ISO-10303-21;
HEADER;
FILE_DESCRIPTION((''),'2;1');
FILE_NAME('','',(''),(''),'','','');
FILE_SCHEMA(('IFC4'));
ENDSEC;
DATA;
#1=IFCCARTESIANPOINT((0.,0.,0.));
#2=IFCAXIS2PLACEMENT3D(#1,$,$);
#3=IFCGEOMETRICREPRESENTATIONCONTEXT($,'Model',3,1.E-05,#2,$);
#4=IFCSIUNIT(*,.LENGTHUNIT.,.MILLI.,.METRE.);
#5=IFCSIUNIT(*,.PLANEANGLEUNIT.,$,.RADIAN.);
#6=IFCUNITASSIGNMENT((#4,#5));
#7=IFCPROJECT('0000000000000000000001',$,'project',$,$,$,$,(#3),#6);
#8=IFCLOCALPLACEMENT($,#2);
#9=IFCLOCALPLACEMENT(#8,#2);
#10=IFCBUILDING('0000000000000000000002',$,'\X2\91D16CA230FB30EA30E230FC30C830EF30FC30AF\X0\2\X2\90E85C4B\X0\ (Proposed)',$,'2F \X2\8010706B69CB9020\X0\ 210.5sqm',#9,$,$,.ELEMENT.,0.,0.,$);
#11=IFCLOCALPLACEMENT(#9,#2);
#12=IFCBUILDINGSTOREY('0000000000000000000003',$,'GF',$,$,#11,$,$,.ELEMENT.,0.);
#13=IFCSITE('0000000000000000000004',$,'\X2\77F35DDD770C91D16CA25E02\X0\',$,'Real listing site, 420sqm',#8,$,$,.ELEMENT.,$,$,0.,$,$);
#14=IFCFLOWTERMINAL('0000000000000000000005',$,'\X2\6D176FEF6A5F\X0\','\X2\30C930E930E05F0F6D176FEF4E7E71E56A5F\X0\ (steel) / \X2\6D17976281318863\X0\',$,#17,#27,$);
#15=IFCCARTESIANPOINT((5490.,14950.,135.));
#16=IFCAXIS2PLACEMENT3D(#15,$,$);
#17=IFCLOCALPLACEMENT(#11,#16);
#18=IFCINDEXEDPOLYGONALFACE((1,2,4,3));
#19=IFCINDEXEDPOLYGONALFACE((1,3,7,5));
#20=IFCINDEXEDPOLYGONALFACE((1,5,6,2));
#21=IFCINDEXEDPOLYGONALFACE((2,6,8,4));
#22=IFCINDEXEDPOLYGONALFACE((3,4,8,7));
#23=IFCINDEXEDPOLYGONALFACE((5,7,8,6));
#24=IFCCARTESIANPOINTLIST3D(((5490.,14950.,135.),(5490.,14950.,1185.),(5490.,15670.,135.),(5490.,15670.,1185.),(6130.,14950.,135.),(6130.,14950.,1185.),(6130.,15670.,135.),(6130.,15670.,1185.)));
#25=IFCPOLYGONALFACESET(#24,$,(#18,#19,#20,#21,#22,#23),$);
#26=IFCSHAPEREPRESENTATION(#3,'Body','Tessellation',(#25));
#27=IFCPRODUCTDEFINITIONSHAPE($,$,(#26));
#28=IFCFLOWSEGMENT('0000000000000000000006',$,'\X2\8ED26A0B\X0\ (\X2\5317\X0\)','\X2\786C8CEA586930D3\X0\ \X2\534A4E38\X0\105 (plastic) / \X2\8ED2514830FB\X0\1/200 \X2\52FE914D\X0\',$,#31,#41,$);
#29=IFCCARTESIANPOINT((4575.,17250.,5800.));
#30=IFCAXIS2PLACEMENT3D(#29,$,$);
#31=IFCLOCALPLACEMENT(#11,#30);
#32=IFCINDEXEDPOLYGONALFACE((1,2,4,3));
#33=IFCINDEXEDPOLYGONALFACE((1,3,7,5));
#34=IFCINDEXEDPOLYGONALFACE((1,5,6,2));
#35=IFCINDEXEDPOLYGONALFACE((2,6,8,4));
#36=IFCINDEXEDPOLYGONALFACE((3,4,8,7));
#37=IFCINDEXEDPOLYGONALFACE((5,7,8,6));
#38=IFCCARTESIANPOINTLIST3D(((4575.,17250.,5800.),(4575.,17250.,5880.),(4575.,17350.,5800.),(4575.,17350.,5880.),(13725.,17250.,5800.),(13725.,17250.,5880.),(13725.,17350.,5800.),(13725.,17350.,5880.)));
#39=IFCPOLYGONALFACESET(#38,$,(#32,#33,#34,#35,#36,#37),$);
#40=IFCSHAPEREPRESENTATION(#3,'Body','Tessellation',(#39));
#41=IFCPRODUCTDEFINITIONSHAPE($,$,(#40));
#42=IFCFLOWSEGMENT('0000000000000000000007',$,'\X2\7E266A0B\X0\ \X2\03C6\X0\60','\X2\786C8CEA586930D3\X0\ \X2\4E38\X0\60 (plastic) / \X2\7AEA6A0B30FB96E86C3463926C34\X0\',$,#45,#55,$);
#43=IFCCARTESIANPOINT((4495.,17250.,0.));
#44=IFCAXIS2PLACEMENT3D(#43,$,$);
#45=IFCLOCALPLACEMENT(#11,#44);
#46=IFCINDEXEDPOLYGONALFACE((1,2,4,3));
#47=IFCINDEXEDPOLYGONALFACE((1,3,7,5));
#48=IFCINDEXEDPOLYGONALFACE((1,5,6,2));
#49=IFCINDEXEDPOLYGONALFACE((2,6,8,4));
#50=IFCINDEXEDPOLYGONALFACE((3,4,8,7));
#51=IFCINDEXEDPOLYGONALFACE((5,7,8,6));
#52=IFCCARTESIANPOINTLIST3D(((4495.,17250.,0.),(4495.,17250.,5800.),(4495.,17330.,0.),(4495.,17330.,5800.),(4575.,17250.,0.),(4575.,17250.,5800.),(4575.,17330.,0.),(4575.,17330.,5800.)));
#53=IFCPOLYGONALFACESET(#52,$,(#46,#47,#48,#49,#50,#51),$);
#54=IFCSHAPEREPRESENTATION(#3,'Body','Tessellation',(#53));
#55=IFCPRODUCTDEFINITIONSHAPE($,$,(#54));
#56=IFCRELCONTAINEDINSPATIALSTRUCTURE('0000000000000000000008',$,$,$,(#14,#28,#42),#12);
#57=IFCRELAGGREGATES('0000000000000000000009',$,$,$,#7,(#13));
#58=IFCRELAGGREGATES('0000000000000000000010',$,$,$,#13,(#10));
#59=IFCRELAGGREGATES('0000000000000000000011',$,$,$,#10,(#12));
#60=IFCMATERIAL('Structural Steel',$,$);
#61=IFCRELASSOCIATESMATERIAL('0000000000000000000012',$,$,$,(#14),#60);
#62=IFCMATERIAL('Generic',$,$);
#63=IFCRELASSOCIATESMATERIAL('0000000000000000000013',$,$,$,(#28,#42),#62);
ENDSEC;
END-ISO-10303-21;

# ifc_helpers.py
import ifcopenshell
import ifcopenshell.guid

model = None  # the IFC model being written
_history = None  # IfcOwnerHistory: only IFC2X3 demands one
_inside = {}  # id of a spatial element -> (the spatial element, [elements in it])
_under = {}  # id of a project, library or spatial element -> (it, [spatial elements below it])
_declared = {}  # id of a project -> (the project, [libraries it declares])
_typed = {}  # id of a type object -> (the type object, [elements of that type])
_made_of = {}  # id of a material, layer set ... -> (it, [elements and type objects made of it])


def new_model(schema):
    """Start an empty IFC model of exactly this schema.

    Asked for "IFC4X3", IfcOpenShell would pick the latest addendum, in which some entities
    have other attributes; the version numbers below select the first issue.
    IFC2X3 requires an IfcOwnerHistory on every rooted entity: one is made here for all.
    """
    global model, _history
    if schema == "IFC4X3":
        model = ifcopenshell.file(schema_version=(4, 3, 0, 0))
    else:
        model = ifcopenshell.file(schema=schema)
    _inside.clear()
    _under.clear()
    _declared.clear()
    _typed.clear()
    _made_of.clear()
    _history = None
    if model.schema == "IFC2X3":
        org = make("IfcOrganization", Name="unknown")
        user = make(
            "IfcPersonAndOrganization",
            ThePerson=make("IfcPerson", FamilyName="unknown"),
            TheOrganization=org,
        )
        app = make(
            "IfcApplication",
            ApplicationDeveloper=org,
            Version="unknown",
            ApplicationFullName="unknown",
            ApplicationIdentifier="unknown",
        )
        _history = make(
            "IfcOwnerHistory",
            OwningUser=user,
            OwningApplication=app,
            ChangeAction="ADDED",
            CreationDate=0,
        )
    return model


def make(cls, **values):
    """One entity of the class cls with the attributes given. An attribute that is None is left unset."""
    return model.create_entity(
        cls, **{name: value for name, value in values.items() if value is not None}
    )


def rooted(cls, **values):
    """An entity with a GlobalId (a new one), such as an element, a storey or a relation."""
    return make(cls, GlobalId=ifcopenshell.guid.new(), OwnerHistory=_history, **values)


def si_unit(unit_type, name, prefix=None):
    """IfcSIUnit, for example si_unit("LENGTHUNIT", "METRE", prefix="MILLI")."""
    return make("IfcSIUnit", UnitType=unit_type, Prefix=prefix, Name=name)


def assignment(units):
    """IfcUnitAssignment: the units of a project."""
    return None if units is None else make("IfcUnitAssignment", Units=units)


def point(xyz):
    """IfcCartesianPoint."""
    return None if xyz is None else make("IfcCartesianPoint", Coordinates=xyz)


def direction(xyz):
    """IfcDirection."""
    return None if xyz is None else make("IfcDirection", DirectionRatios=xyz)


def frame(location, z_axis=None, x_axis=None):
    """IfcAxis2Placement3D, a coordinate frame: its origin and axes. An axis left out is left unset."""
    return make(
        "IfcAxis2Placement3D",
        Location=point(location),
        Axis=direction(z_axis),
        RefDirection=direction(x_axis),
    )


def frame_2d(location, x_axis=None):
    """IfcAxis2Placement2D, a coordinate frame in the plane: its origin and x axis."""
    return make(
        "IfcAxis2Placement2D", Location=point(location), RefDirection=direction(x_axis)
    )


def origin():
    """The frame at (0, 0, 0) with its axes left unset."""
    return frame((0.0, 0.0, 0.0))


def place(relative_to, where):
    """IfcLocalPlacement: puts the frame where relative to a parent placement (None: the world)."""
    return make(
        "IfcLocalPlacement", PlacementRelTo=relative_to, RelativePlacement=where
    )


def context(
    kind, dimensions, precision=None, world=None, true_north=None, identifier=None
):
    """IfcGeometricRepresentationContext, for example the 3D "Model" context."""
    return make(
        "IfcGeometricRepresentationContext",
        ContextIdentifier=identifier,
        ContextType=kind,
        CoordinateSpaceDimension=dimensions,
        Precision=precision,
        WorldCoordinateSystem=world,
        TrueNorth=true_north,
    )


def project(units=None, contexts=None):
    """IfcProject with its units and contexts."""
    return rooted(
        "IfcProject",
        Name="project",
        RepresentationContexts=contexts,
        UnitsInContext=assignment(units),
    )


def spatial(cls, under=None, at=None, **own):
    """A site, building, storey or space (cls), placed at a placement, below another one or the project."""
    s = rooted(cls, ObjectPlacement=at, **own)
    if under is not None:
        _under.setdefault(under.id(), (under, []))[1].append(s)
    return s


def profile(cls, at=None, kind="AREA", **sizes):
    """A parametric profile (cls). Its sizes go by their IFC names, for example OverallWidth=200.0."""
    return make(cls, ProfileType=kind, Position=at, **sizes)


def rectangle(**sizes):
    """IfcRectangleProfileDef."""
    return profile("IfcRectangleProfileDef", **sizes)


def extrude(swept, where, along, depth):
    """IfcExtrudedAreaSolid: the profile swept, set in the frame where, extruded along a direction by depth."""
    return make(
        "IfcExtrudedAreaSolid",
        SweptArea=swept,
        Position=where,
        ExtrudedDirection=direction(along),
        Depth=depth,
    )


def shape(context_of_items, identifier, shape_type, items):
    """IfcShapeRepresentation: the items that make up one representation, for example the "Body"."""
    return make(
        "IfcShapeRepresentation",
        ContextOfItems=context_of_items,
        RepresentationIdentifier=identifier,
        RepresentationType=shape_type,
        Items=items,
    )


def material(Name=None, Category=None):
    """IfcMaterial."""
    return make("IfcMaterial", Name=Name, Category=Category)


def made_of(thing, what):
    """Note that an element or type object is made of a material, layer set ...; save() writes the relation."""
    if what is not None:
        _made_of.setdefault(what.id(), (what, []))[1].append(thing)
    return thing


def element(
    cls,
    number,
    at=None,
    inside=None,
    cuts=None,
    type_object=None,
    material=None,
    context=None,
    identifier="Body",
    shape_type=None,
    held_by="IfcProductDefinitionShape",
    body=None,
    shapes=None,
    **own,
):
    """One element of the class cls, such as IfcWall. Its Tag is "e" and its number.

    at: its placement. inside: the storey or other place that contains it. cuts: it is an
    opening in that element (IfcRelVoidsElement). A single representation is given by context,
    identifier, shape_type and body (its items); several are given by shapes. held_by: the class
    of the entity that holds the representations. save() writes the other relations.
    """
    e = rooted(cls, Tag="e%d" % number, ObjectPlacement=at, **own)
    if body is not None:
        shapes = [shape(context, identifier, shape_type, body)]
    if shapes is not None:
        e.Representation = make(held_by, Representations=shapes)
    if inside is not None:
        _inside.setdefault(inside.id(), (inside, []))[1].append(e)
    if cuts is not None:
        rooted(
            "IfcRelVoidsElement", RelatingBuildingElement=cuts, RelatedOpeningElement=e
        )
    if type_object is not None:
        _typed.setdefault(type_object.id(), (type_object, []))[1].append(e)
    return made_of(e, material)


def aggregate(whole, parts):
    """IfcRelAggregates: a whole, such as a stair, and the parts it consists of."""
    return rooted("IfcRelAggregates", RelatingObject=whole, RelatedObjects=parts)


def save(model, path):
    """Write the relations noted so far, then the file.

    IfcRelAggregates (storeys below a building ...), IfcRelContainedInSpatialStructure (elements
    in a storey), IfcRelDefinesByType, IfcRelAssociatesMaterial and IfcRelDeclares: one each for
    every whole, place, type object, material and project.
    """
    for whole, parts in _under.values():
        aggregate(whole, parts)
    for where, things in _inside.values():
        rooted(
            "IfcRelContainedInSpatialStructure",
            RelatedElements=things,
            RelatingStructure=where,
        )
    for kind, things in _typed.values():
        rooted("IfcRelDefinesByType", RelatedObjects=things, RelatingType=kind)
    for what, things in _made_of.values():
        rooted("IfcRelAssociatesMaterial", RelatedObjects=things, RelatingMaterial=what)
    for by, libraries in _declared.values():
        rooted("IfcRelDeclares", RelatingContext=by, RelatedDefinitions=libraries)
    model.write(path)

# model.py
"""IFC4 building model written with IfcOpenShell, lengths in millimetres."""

from ifc_helpers import new_model, si_unit, frame, frame_2d, origin, place, context, project, spatial, rectangle, extrude, material, element, save


model = new_model("IFC4")

# Units and contexts
model_context = context("Model", 3, precision=1e-05, world=origin())
ifc_project = project(units=[si_unit("LENGTHUNIT", "METRE", prefix="MILLI"), si_unit("PLANEANGLEUNIT", "RADIAN")], contexts=[model_context])

# Site, building, storey
site_placement = place(None, origin())
site = spatial("IfcSite", under=ifc_project, at=site_placement, Name="石川県金沢市", ObjectType="Real listing site, 420sqm", CompositionType="ELEMENT", RefElevation=0.0)
building_placement = place(site_placement, origin())
building = spatial("IfcBuilding", under=site, at=building_placement, Name="金沢・リモートワーク2部屋 (Proposed)", ObjectType="2F 耐火構造 210.5sqm", CompositionType="ELEMENT", ElevationOfRefHeight=0.0, ElevationOfTerrain=0.0)
storey_placement = place(building_placement, origin())
storey = spatial("IfcBuildingStorey", under=building, at=storey_placement, Name="GF", CompositionType="ELEMENT", Elevation=0.0)

# Flow terminal
ifc_material_1 = material(Name="Structural Steel")
flow_terminal_placement = place(storey_placement, frame((5490.0, 14950.0, 135.0)))
element("IfcFlowTerminal", 1, at=flow_terminal_placement, inside=storey, material=ifc_material_1, Name="洗濯機", Description="ドラム式洗濯乾燥機 (steel) / 洗面脱衣", context=model_context, shape_type="SweptSolid", body=[
    extrude(rectangle(XDim=640.0, YDim=720.0, at=frame_2d((320.0, 360.0))), frame((5490.0, 14950.0, 135.0)), (0.0, 0.0, 1.0), 1050.0),
])

# Flow segments
ifc_material_2 = material(Name="Generic")
flow_segment_1_placement = place(storey_placement, frame((4575.0, 17250.0, 5800.0)))
element("IfcFlowSegment", 2, at=flow_segment_1_placement, inside=storey, material=ifc_material_2, Name="軒樋 (北)", Description="硬質塩ビ 半丸105 (plastic) / 軒先・1/200 勾配", context=model_context, shape_type="SweptSolid", body=[
    extrude(rectangle(XDim=9150.0, YDim=100.0, at=frame_2d((4575.0, 50.0))), frame((4575.0, 17250.0, 5800.0)), (0.0, 0.0, 1.0), 80.0),
])
flow_segment_2_placement = place(storey_placement, frame((4495.0, 17250.0, 0.0)))
element("IfcFlowSegment", 3, at=flow_segment_2_placement, inside=storey, material=ifc_material_2, Name="縦樋 φ60", Description="硬質塩ビ 丸60 (plastic) / 竪樋・雨水排水", context=model_context, shape_type="SweptSolid", body=[
    extrude(rectangle(XDim=80.0, YDim=80.0, at=frame_2d((40.0, 40.0))), frame((4495.0, 17250.0, 0.0)), (0.0, 0.0, 1.0), 5800.0),
])

save(model, "model.ifc")
